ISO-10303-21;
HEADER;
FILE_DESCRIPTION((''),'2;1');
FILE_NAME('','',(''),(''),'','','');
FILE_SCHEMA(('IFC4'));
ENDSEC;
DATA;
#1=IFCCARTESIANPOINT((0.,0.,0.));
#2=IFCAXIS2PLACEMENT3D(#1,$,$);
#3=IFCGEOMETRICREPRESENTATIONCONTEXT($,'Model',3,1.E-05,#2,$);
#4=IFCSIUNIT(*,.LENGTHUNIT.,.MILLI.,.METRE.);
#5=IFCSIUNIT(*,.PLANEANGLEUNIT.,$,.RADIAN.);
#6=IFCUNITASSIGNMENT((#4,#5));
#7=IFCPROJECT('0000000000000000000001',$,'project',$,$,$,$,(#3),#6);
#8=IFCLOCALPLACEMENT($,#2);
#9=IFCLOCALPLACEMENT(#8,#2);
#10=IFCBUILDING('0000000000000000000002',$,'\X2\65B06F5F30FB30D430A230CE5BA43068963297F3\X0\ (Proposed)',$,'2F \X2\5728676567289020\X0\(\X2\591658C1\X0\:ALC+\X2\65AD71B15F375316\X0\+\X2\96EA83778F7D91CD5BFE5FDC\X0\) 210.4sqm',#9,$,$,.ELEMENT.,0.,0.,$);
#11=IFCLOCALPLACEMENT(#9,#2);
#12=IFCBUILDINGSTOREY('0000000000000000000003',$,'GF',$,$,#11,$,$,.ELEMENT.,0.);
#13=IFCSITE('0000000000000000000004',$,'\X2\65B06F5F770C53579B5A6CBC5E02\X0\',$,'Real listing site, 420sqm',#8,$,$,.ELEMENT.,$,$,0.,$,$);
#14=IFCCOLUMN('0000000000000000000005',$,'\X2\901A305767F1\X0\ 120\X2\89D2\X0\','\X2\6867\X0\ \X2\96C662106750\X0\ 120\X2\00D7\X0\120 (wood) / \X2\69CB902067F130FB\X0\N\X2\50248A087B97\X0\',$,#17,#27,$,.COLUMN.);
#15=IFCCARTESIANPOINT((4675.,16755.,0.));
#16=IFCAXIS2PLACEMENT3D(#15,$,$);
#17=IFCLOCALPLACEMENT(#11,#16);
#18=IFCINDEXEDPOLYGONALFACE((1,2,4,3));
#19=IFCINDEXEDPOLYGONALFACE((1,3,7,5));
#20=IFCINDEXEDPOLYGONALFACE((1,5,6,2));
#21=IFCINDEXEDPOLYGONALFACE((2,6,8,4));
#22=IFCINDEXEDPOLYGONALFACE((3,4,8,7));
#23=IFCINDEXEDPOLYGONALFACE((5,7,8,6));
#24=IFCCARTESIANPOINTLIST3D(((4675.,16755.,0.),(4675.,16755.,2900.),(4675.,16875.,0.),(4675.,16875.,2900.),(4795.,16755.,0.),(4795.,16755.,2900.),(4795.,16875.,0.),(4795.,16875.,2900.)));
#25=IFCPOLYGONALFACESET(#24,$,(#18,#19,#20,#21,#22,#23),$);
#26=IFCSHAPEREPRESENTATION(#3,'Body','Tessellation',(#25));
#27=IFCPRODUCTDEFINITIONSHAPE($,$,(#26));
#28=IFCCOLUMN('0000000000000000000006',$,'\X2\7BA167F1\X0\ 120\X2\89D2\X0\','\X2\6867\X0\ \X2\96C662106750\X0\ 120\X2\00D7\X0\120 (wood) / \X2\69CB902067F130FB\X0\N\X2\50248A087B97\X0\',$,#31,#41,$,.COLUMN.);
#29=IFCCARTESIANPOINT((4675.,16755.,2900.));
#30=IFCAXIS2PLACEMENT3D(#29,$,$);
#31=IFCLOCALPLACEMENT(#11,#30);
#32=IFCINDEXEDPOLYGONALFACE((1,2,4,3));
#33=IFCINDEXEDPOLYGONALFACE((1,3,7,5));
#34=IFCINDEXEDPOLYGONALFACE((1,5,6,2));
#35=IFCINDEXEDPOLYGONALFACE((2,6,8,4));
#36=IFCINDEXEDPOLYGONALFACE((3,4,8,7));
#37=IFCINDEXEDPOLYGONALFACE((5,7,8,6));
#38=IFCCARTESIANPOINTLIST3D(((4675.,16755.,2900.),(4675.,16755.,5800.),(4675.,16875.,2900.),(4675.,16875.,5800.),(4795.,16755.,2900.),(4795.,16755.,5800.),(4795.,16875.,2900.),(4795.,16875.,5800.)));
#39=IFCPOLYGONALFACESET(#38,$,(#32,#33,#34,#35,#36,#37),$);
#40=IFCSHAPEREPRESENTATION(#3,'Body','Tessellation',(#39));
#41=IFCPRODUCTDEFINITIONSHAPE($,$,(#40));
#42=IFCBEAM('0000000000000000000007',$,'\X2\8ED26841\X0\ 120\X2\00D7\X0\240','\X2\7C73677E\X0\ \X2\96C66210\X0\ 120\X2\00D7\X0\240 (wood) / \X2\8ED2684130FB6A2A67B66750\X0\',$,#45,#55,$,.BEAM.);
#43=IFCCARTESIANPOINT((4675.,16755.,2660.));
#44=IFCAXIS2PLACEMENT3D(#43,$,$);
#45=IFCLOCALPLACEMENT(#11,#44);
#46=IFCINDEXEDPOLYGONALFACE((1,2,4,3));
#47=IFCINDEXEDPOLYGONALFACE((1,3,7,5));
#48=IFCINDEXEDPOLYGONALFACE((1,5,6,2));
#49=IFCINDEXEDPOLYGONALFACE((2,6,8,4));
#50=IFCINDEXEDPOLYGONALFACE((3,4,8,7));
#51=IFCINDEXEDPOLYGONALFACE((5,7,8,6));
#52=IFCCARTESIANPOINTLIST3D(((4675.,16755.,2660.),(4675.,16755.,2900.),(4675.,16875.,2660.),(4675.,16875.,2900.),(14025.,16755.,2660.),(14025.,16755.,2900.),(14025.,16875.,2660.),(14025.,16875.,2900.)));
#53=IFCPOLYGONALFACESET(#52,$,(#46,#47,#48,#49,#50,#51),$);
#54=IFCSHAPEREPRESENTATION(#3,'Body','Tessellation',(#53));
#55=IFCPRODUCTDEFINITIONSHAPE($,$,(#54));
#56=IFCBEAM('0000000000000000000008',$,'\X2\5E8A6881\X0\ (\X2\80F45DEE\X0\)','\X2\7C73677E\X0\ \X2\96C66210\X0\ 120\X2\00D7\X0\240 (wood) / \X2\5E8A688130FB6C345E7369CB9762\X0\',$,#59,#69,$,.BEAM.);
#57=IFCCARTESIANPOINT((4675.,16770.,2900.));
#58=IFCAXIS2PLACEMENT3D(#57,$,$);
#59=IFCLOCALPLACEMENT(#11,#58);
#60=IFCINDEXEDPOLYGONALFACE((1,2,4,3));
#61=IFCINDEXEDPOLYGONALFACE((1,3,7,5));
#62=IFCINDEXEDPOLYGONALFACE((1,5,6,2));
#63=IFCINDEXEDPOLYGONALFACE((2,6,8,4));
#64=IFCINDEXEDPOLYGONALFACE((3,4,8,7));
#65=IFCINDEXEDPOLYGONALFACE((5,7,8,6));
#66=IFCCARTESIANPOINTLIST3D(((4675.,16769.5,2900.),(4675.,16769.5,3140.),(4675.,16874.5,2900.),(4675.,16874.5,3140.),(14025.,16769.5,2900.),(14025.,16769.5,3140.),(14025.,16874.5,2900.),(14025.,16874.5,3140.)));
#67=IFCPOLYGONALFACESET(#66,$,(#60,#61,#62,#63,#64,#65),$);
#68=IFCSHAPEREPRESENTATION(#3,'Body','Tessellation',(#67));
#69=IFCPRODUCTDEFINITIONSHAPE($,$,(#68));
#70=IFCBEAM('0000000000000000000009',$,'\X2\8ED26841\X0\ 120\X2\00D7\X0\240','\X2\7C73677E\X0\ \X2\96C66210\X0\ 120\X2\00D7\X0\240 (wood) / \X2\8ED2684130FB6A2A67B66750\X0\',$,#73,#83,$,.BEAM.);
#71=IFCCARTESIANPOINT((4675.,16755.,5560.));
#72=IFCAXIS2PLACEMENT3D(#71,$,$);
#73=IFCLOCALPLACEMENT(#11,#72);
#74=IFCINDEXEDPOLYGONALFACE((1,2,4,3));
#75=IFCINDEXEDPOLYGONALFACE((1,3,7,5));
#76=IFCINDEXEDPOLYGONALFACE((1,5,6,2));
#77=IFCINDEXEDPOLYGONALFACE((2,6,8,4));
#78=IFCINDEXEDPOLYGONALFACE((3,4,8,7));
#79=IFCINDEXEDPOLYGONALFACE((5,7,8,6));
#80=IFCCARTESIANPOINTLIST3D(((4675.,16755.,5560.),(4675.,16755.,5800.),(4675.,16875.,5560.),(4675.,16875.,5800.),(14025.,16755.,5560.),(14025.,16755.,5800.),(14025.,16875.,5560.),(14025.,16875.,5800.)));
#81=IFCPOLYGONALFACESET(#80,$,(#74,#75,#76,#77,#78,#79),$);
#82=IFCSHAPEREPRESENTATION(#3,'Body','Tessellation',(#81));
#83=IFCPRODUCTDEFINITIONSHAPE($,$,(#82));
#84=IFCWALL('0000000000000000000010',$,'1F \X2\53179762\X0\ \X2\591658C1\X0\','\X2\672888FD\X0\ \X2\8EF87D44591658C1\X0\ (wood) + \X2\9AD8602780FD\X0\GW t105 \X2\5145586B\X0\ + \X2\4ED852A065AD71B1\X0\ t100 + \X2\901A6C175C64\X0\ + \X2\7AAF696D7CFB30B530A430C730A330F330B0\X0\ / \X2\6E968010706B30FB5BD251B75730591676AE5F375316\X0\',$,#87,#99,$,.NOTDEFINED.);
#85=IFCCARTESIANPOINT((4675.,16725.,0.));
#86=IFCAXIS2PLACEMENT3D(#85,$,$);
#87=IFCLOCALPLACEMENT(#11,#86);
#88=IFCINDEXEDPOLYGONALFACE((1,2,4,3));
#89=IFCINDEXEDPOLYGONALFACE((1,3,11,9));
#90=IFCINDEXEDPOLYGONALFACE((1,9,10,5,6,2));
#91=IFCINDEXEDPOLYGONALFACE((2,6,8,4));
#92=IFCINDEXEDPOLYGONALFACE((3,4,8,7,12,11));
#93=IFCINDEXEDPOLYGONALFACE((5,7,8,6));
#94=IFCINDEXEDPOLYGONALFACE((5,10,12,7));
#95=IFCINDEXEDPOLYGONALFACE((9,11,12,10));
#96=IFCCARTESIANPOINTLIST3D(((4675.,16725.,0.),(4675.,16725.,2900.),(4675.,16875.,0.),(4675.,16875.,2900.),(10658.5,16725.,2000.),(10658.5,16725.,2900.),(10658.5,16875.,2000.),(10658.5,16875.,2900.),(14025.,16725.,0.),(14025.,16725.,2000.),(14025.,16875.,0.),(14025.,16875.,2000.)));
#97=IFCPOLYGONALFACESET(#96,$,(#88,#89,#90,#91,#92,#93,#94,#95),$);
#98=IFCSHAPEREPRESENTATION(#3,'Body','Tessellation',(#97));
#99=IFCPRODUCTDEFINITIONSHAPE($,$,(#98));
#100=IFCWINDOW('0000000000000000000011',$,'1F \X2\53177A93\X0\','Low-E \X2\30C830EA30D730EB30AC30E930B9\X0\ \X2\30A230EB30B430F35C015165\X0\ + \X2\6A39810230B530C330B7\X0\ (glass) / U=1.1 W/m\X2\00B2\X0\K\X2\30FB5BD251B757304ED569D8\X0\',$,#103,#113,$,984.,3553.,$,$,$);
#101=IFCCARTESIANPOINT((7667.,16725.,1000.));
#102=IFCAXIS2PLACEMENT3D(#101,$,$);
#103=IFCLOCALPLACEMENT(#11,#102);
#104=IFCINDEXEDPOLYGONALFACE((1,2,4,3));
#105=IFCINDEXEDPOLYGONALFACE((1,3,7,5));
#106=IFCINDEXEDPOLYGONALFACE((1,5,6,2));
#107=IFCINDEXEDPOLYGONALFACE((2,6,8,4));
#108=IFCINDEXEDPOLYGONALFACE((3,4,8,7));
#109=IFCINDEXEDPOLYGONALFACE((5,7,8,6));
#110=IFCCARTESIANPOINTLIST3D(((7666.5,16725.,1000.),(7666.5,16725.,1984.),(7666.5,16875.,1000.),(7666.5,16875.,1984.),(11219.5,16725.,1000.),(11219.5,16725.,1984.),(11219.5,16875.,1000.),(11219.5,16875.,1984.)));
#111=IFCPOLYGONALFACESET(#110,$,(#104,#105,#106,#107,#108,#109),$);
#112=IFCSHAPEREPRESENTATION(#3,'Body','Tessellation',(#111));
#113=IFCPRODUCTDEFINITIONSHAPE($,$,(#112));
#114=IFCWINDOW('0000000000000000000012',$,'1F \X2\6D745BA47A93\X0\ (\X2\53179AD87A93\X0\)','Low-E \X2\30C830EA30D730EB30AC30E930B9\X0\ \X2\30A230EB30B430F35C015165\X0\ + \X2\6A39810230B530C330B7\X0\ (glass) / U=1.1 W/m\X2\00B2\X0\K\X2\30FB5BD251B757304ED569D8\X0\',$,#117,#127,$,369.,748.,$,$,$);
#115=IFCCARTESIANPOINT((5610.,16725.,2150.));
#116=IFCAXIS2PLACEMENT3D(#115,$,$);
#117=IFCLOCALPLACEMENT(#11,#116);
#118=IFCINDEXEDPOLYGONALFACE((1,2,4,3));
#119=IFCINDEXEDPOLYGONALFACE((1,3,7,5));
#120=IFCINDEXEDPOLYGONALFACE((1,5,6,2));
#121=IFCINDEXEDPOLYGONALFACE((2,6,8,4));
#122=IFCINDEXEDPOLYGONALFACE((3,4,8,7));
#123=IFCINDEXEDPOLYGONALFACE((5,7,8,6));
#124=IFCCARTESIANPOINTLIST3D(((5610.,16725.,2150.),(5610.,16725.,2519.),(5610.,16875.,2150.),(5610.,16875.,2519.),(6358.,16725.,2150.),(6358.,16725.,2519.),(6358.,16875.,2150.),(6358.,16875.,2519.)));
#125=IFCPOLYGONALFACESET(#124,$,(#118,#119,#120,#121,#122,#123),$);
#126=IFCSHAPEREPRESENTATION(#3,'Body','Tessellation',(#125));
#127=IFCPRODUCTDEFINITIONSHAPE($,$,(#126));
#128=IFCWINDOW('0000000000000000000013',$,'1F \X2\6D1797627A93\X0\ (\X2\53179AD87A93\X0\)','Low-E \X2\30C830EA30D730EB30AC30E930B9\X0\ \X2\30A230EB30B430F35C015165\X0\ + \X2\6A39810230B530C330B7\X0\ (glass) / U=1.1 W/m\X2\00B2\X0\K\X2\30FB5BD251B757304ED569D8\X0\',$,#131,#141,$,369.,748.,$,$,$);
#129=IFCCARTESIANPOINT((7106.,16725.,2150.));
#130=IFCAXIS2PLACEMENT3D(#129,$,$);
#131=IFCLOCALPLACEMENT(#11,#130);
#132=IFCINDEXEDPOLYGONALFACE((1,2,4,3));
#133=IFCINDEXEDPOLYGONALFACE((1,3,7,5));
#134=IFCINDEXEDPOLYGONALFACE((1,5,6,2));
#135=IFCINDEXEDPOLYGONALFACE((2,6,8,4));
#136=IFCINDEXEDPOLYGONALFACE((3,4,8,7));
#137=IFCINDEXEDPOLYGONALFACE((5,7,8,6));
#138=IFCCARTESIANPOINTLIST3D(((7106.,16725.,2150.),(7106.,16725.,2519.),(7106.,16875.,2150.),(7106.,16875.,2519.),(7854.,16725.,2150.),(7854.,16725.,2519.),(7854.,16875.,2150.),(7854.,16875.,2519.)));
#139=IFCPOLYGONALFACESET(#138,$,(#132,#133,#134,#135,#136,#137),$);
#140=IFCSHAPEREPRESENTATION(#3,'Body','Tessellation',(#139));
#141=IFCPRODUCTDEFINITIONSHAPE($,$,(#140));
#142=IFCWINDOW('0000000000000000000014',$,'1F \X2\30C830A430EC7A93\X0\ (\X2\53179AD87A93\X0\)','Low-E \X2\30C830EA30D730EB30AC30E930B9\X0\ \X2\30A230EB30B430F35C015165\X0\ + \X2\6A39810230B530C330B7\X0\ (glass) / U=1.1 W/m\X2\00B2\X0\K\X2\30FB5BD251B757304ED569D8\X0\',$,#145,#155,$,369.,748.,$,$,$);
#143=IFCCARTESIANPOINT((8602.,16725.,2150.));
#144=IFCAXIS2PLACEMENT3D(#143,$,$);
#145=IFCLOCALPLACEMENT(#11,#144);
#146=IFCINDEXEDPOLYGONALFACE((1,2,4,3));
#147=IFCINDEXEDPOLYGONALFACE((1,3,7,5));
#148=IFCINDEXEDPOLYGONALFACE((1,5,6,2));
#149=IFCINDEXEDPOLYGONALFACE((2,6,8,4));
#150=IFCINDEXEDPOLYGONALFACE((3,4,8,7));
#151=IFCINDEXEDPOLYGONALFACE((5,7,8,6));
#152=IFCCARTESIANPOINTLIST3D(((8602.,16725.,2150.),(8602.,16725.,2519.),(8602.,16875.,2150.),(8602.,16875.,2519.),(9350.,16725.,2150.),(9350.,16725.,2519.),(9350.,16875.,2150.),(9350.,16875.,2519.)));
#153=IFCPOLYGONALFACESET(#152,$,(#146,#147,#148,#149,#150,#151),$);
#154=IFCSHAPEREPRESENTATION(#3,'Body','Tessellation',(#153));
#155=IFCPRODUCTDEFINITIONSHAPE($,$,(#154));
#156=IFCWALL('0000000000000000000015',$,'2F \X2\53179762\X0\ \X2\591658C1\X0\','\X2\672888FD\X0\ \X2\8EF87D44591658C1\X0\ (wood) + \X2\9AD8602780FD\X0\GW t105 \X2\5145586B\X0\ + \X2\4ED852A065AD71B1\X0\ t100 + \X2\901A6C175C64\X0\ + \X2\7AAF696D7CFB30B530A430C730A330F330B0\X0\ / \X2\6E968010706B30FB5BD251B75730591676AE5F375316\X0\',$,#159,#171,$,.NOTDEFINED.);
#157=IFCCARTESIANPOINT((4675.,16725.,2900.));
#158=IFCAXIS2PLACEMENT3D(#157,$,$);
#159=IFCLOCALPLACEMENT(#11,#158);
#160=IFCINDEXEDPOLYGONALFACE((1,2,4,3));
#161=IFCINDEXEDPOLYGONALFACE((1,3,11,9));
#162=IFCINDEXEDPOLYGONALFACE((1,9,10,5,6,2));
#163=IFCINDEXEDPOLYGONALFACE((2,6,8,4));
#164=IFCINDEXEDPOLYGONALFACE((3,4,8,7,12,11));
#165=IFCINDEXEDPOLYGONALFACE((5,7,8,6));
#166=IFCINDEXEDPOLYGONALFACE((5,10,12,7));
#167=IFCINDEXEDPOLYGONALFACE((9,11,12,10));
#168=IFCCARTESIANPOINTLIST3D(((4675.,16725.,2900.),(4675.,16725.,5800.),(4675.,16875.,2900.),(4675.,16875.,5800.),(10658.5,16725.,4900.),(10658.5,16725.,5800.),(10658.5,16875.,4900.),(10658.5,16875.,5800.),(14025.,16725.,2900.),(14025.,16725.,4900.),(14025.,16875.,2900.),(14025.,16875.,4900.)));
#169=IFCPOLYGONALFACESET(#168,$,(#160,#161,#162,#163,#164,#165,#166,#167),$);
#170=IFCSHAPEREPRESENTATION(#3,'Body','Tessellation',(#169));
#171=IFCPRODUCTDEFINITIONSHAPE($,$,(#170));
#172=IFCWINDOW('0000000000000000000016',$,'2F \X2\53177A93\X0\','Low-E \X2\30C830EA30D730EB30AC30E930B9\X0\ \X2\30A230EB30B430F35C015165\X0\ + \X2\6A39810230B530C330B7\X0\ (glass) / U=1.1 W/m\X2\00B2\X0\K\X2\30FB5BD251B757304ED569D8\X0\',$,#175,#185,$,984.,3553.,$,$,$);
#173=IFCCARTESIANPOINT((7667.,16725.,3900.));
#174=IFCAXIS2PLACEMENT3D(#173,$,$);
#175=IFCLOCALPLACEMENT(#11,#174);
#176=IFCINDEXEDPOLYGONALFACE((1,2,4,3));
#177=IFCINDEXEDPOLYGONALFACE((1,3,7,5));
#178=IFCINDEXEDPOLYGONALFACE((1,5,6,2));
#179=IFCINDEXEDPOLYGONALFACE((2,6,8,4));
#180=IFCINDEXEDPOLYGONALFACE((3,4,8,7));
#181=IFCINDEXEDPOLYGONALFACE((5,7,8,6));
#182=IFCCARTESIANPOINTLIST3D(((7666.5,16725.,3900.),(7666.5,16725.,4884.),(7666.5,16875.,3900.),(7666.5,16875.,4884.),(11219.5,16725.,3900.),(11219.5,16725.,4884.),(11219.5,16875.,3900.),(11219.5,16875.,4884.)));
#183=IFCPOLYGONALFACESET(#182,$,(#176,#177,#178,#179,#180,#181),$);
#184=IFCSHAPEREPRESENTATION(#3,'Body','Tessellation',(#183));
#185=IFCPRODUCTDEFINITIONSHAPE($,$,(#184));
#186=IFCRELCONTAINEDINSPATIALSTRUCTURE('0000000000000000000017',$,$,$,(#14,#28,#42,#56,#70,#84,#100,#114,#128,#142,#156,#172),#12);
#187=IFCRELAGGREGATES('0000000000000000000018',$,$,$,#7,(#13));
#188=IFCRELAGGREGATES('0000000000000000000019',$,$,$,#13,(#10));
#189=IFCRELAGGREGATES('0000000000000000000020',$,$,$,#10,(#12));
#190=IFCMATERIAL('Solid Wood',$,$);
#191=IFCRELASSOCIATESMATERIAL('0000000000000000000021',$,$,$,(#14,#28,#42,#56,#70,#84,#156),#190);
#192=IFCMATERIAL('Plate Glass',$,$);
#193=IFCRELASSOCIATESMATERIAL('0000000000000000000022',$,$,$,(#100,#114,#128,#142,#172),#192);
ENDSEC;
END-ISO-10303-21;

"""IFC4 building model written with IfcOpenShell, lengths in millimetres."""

from ifc_helpers import new_model, si_unit, frame, frame_2d, origin, place, context, project, spatial, rectangle, extrude, material, element, fill, save


model = new_model("IFC4")

# Units and contexts
model_context = context("Model", 3, precision=1e-05, world=origin())
ifc_project = project(units=[si_unit("LENGTHUNIT", "METRE", prefix="MILLI"), si_unit("PLANEANGLEUNIT", "RADIAN")], contexts=[model_context])

# Site, building, storey
site_placement = place(None, origin())
site = spatial("IfcSite", under=ifc_project, at=site_placement, Name="新潟県南魚沼市", ObjectType="Real listing site, 420sqm", CompositionType="ELEMENT", RefElevation=0.0)
building_placement = place(site_placement, origin())
building = spatial("IfcBuilding", under=site, at=building_placement, Name="新潟・ピアノ室と防音 (Proposed)", ObjectType="2F 在来木造(外壁:ALC+断熱強化+雪荷载重対応) 210.4sqm", CompositionType="ELEMENT", ElevationOfRefHeight=0.0, ElevationOfTerrain=0.0)
storey_placement = place(building_placement, origin())
storey = spatial("IfcBuildingStorey", under=building, at=storey_placement, Name="GF", CompositionType="ELEMENT", Elevation=0.0)

# Columns
ifc_material_1 = material(Name="Solid Wood")
column_1_placement = place(storey_placement, frame((4675.0, 16755.0, 0.0)))
element("IfcColumn", 1, at=column_1_placement, inside=storey, material=ifc_material_1, Name="通し柱 120角", Description="桧 集成材 120×120 (wood) / 構造柱・N値計算", PredefinedType="COLUMN", context=model_context, shape_type="SweptSolid", body=[
    extrude(rectangle(XDim=120.0, YDim=120.0, at=frame_2d((60.0, 60.0))), frame((4675.0, 16755.0, 0.0)), (0.0, 0.0, 1.0), 2900.0),
])
column_2_placement = place(storey_placement, frame((4675.0, 16755.0, 2900.0)))
element("IfcColumn", 2, at=column_2_placement, inside=storey, material=ifc_material_1, Name="管柱 120角", Description="桧 集成材 120×120 (wood) / 構造柱・N値計算", PredefinedType="COLUMN", context=model_context, shape_type="SweptSolid", body=[
    extrude(rectangle(XDim=120.0, YDim=120.0, at=frame_2d((60.0, 60.0))), frame((4675.0, 16755.0, 2900.0)), (0.0, 0.0, 1.0), 2900.0),
])

# Beams
beam_1_placement = place(storey_placement, frame((4675.0, 16755.0, 2660.0)))
element("IfcBeam", 3, at=beam_1_placement, inside=storey, material=ifc_material_1, Name="軒桁 120×240", Description="米松 集成 120×240 (wood) / 軒桁・横架材", PredefinedType="BEAM", context=model_context, shape_type="SweptSolid", body=[
    extrude(rectangle(XDim=9350.0, YDim=120.0, at=frame_2d((4675.0, 60.0))), frame((4675.0, 16755.0, 2660.0)), (0.0, 0.0, 1.0), 240.0),
])
beam_2_placement = place(storey_placement, frame((4675.0, 16770.0, 2900.0)))
element("IfcBeam", 4, at=beam_2_placement, inside=storey, material=ifc_material_1, Name="床梁 (胴差)", Description="米松 集成 120×240 (wood) / 床梁・水平構面", PredefinedType="BEAM", context=model_context, shape_type="SweptSolid", body=[
    extrude(rectangle(XDim=9350.0, YDim=105.0, at=frame_2d((4675.0, 52.0))), frame((4675.0, 16770.0, 2900.0)), (0.0, 0.0, 1.0), 240.0),
])
beam_3_placement = place(storey_placement, frame((4675.0, 16755.0, 5560.0)))
element("IfcBeam", 5, at=beam_3_placement, inside=storey, material=ifc_material_1, Name="軒桁 120×240", Description="米松 集成 120×240 (wood) / 軒桁・横架材", PredefinedType="BEAM", context=model_context, shape_type="SweptSolid", body=[
    extrude(rectangle(XDim=9350.0, YDim=120.0, at=frame_2d((4675.0, 60.0))), frame((4675.0, 16755.0, 5560.0)), (0.0, 0.0, 1.0), 240.0),
])

# Wall, openings, windows
wall_1_placement = place(storey_placement, frame((4675.0, 16725.0, 0.0)))
wall_1 = element("IfcWall", 6, at=wall_1_placement, inside=storey, material=ifc_material_1, Name="1F 北面 外壁", Description="木製 軸組外壁 (wood) + 高性能GW t105 充填 + 付加断熱 t100 + 通気層 + 窯業系サイディング / 準耐火・寒冷地外皮強化", PredefinedType="NOTDEFINED", context=model_context, shape_type="SweptSolid", body=[
    extrude(rectangle(XDim=9350.0, YDim=150.0, at=frame_2d((4675.0, 75.0))), frame((4675.0, 16725.0, 0.0)), (0.0, 0.0, 1.0), 2900.0),
])
opening_1_placement = place(storey_placement, frame((7667.0, 16725.0, 1000.0)))
opening_1 = element("IfcOpeningElement", 7, at=opening_1_placement, cuts=wall_1, PredefinedType="NOTDEFINED", context=model_context, shape_type="SweptSolid", body=[
    extrude(rectangle(XDim=3553.0, YDim=150.0, at=frame_2d((1776.0, 75.0))), frame((7667.0, 16725.0, 1000.0)), (0.0, 0.0, 1.0), 984.0),
])
opening_2_placement = place(storey_placement, frame((5610.0, 16725.0, 2150.0)))
opening_2 = element("IfcOpeningElement", 8, at=opening_2_placement, cuts=wall_1, PredefinedType="NOTDEFINED", context=model_context, shape_type="SweptSolid", body=[
    extrude(rectangle(XDim=748.0, YDim=150.0, at=frame_2d((374.0, 75.0))), frame((5610.0, 16725.0, 2150.0)), (0.0, 0.0, 1.0), 369.0),
])
opening_3_placement = place(storey_placement, frame((7106.0, 16725.0, 2150.0)))
opening_3 = element("IfcOpeningElement", 9, at=opening_3_placement, cuts=wall_1, PredefinedType="NOTDEFINED", context=model_context, shape_type="SweptSolid", body=[
    extrude(rectangle(XDim=748.0, YDim=150.0, at=frame_2d((374.0, 75.0))), frame((7106.0, 16725.0, 2150.0)), (0.0, 0.0, 1.0), 369.0),
])
opening_4_placement = place(storey_placement, frame((8602.0, 16725.0, 2150.0)))
opening_4 = element("IfcOpeningElement", 10, at=opening_4_placement, cuts=wall_1, PredefinedType="NOTDEFINED", context=model_context, shape_type="SweptSolid", body=[
    extrude(rectangle(XDim=748.0, YDim=150.0, at=frame_2d((374.0, 75.0))), frame((8602.0, 16725.0, 2150.0)), (0.0, 0.0, 1.0), 369.0),
])
ifc_material_2 = material(Name="Plate Glass")
window_1_placement = place(storey_placement, frame((7667.0, 16725.0, 1000.0)))
window_1 = element("IfcWindow", 11, at=window_1_placement, inside=storey, material=ifc_material_2, Name="1F 北窓", Description="Low-E トリプルガラス アルゴン封入 + 樹脂サッシ (glass) / U=1.1 W/m²K・寒冷地仕様", OverallHeight=984.0, OverallWidth=3553.0, context=model_context, shape_type="SweptSolid", body=[
    extrude(rectangle(XDim=3553.0, YDim=150.0, at=frame_2d((1776.0, 75.0))), frame((7667.0, 16725.0, 1000.0)), (0.0, 0.0, 1.0), 984.0),
])
fill(opening_1, window_1)
window_2_placement = place(storey_placement, frame((5610.0, 16725.0, 2150.0)))
window_2 = element("IfcWindow", 12, at=window_2_placement, inside=storey, material=ifc_material_2, Name="1F 浴室窓 (北高窓)", Description="Low-E トリプルガラス アルゴン封入 + 樹脂サッシ (glass) / U=1.1 W/m²K・寒冷地仕様", OverallHeight=369.0, OverallWidth=748.0, context=model_context, shape_type="SweptSolid", body=[
    extrude(rectangle(XDim=748.0, YDim=150.0, at=frame_2d((374.0, 75.0))), frame((5610.0, 16725.0, 2150.0)), (0.0, 0.0, 1.0), 369.0),
])
fill(opening_2, window_2)
window_3_placement = place(storey_placement, frame((7106.0, 16725.0, 2150.0)))
window_3 = element("IfcWindow", 13, at=window_3_placement, inside=storey, material=ifc_material_2, Name="1F 洗面窓 (北高窓)", Description="Low-E トリプルガラス アルゴン封入 + 樹脂サッシ (glass) / U=1.1 W/m²K・寒冷地仕様", OverallHeight=369.0, OverallWidth=748.0, context=model_context, shape_type="SweptSolid", body=[
    extrude(rectangle(XDim=748.0, YDim=150.0, at=frame_2d((374.0, 75.0))), frame((7106.0, 16725.0, 2150.0)), (0.0, 0.0, 1.0), 369.0),
])
fill(opening_3, window_3)
window_4_placement = place(storey_placement, frame((8602.0, 16725.0, 2150.0)))
window_4 = element("IfcWindow", 14, at=window_4_placement, inside=storey, material=ifc_material_2, Name="1F トイレ窓 (北高窓)", Description="Low-E トリプルガラス アルゴン封入 + 樹脂サッシ (glass) / U=1.1 W/m²K・寒冷地仕様", OverallHeight=369.0, OverallWidth=748.0, context=model_context, shape_type="SweptSolid", body=[
    extrude(rectangle(XDim=748.0, YDim=150.0, at=frame_2d((374.0, 75.0))), frame((8602.0, 16725.0, 2150.0)), (0.0, 0.0, 1.0), 369.0),
])
fill(opening_4, window_4)

# Wall, opening, window
wall_2_placement = place(storey_placement, frame((4675.0, 16725.0, 2900.0)))
wall_2 = element("IfcWall", 15, at=wall_2_placement, inside=storey, material=ifc_material_1, Name="2F 北面 外壁", Description="木製 軸組外壁 (wood) + 高性能GW t105 充填 + 付加断熱 t100 + 通気層 + 窯業系サイディング / 準耐火・寒冷地外皮強化", PredefinedType="NOTDEFINED", context=model_context, shape_type="SweptSolid", body=[
    extrude(rectangle(XDim=9350.0, YDim=150.0, at=frame_2d((4675.0, 75.0))), frame((4675.0, 16725.0, 2900.0)), (0.0, 0.0, 1.0), 2900.0),
])
opening_5_placement = place(storey_placement, frame((7667.0, 16725.0, 3900.0)))
opening_5 = element("IfcOpeningElement", 16, at=opening_5_placement, cuts=wall_2, PredefinedType="NOTDEFINED", context=model_context, shape_type="SweptSolid", body=[
    extrude(rectangle(XDim=3553.0, YDim=150.0, at=frame_2d((1776.0, 75.0))), frame((7667.0, 16725.0, 3900.0)), (0.0, 0.0, 1.0), 984.0),
])
window_5_placement = place(storey_placement, frame((7667.0, 16725.0, 3900.0)))
window_5 = element("IfcWindow", 17, at=window_5_placement, inside=storey, material=ifc_material_2, Name="2F 北窓", Description="Low-E トリプルガラス アルゴン封入 + 樹脂サッシ (glass) / U=1.1 W/m²K・寒冷地仕様", OverallHeight=984.0, OverallWidth=3553.0, context=model_context, shape_type="SweptSolid", body=[
    extrude(rectangle(XDim=3553.0, YDim=150.0, at=frame_2d((1776.0, 75.0))), frame((7667.0, 16725.0, 3900.0)), (0.0, 0.0, 1.0), 984.0),
])
fill(opening_5, window_5)

save(model, "model.ifc")
